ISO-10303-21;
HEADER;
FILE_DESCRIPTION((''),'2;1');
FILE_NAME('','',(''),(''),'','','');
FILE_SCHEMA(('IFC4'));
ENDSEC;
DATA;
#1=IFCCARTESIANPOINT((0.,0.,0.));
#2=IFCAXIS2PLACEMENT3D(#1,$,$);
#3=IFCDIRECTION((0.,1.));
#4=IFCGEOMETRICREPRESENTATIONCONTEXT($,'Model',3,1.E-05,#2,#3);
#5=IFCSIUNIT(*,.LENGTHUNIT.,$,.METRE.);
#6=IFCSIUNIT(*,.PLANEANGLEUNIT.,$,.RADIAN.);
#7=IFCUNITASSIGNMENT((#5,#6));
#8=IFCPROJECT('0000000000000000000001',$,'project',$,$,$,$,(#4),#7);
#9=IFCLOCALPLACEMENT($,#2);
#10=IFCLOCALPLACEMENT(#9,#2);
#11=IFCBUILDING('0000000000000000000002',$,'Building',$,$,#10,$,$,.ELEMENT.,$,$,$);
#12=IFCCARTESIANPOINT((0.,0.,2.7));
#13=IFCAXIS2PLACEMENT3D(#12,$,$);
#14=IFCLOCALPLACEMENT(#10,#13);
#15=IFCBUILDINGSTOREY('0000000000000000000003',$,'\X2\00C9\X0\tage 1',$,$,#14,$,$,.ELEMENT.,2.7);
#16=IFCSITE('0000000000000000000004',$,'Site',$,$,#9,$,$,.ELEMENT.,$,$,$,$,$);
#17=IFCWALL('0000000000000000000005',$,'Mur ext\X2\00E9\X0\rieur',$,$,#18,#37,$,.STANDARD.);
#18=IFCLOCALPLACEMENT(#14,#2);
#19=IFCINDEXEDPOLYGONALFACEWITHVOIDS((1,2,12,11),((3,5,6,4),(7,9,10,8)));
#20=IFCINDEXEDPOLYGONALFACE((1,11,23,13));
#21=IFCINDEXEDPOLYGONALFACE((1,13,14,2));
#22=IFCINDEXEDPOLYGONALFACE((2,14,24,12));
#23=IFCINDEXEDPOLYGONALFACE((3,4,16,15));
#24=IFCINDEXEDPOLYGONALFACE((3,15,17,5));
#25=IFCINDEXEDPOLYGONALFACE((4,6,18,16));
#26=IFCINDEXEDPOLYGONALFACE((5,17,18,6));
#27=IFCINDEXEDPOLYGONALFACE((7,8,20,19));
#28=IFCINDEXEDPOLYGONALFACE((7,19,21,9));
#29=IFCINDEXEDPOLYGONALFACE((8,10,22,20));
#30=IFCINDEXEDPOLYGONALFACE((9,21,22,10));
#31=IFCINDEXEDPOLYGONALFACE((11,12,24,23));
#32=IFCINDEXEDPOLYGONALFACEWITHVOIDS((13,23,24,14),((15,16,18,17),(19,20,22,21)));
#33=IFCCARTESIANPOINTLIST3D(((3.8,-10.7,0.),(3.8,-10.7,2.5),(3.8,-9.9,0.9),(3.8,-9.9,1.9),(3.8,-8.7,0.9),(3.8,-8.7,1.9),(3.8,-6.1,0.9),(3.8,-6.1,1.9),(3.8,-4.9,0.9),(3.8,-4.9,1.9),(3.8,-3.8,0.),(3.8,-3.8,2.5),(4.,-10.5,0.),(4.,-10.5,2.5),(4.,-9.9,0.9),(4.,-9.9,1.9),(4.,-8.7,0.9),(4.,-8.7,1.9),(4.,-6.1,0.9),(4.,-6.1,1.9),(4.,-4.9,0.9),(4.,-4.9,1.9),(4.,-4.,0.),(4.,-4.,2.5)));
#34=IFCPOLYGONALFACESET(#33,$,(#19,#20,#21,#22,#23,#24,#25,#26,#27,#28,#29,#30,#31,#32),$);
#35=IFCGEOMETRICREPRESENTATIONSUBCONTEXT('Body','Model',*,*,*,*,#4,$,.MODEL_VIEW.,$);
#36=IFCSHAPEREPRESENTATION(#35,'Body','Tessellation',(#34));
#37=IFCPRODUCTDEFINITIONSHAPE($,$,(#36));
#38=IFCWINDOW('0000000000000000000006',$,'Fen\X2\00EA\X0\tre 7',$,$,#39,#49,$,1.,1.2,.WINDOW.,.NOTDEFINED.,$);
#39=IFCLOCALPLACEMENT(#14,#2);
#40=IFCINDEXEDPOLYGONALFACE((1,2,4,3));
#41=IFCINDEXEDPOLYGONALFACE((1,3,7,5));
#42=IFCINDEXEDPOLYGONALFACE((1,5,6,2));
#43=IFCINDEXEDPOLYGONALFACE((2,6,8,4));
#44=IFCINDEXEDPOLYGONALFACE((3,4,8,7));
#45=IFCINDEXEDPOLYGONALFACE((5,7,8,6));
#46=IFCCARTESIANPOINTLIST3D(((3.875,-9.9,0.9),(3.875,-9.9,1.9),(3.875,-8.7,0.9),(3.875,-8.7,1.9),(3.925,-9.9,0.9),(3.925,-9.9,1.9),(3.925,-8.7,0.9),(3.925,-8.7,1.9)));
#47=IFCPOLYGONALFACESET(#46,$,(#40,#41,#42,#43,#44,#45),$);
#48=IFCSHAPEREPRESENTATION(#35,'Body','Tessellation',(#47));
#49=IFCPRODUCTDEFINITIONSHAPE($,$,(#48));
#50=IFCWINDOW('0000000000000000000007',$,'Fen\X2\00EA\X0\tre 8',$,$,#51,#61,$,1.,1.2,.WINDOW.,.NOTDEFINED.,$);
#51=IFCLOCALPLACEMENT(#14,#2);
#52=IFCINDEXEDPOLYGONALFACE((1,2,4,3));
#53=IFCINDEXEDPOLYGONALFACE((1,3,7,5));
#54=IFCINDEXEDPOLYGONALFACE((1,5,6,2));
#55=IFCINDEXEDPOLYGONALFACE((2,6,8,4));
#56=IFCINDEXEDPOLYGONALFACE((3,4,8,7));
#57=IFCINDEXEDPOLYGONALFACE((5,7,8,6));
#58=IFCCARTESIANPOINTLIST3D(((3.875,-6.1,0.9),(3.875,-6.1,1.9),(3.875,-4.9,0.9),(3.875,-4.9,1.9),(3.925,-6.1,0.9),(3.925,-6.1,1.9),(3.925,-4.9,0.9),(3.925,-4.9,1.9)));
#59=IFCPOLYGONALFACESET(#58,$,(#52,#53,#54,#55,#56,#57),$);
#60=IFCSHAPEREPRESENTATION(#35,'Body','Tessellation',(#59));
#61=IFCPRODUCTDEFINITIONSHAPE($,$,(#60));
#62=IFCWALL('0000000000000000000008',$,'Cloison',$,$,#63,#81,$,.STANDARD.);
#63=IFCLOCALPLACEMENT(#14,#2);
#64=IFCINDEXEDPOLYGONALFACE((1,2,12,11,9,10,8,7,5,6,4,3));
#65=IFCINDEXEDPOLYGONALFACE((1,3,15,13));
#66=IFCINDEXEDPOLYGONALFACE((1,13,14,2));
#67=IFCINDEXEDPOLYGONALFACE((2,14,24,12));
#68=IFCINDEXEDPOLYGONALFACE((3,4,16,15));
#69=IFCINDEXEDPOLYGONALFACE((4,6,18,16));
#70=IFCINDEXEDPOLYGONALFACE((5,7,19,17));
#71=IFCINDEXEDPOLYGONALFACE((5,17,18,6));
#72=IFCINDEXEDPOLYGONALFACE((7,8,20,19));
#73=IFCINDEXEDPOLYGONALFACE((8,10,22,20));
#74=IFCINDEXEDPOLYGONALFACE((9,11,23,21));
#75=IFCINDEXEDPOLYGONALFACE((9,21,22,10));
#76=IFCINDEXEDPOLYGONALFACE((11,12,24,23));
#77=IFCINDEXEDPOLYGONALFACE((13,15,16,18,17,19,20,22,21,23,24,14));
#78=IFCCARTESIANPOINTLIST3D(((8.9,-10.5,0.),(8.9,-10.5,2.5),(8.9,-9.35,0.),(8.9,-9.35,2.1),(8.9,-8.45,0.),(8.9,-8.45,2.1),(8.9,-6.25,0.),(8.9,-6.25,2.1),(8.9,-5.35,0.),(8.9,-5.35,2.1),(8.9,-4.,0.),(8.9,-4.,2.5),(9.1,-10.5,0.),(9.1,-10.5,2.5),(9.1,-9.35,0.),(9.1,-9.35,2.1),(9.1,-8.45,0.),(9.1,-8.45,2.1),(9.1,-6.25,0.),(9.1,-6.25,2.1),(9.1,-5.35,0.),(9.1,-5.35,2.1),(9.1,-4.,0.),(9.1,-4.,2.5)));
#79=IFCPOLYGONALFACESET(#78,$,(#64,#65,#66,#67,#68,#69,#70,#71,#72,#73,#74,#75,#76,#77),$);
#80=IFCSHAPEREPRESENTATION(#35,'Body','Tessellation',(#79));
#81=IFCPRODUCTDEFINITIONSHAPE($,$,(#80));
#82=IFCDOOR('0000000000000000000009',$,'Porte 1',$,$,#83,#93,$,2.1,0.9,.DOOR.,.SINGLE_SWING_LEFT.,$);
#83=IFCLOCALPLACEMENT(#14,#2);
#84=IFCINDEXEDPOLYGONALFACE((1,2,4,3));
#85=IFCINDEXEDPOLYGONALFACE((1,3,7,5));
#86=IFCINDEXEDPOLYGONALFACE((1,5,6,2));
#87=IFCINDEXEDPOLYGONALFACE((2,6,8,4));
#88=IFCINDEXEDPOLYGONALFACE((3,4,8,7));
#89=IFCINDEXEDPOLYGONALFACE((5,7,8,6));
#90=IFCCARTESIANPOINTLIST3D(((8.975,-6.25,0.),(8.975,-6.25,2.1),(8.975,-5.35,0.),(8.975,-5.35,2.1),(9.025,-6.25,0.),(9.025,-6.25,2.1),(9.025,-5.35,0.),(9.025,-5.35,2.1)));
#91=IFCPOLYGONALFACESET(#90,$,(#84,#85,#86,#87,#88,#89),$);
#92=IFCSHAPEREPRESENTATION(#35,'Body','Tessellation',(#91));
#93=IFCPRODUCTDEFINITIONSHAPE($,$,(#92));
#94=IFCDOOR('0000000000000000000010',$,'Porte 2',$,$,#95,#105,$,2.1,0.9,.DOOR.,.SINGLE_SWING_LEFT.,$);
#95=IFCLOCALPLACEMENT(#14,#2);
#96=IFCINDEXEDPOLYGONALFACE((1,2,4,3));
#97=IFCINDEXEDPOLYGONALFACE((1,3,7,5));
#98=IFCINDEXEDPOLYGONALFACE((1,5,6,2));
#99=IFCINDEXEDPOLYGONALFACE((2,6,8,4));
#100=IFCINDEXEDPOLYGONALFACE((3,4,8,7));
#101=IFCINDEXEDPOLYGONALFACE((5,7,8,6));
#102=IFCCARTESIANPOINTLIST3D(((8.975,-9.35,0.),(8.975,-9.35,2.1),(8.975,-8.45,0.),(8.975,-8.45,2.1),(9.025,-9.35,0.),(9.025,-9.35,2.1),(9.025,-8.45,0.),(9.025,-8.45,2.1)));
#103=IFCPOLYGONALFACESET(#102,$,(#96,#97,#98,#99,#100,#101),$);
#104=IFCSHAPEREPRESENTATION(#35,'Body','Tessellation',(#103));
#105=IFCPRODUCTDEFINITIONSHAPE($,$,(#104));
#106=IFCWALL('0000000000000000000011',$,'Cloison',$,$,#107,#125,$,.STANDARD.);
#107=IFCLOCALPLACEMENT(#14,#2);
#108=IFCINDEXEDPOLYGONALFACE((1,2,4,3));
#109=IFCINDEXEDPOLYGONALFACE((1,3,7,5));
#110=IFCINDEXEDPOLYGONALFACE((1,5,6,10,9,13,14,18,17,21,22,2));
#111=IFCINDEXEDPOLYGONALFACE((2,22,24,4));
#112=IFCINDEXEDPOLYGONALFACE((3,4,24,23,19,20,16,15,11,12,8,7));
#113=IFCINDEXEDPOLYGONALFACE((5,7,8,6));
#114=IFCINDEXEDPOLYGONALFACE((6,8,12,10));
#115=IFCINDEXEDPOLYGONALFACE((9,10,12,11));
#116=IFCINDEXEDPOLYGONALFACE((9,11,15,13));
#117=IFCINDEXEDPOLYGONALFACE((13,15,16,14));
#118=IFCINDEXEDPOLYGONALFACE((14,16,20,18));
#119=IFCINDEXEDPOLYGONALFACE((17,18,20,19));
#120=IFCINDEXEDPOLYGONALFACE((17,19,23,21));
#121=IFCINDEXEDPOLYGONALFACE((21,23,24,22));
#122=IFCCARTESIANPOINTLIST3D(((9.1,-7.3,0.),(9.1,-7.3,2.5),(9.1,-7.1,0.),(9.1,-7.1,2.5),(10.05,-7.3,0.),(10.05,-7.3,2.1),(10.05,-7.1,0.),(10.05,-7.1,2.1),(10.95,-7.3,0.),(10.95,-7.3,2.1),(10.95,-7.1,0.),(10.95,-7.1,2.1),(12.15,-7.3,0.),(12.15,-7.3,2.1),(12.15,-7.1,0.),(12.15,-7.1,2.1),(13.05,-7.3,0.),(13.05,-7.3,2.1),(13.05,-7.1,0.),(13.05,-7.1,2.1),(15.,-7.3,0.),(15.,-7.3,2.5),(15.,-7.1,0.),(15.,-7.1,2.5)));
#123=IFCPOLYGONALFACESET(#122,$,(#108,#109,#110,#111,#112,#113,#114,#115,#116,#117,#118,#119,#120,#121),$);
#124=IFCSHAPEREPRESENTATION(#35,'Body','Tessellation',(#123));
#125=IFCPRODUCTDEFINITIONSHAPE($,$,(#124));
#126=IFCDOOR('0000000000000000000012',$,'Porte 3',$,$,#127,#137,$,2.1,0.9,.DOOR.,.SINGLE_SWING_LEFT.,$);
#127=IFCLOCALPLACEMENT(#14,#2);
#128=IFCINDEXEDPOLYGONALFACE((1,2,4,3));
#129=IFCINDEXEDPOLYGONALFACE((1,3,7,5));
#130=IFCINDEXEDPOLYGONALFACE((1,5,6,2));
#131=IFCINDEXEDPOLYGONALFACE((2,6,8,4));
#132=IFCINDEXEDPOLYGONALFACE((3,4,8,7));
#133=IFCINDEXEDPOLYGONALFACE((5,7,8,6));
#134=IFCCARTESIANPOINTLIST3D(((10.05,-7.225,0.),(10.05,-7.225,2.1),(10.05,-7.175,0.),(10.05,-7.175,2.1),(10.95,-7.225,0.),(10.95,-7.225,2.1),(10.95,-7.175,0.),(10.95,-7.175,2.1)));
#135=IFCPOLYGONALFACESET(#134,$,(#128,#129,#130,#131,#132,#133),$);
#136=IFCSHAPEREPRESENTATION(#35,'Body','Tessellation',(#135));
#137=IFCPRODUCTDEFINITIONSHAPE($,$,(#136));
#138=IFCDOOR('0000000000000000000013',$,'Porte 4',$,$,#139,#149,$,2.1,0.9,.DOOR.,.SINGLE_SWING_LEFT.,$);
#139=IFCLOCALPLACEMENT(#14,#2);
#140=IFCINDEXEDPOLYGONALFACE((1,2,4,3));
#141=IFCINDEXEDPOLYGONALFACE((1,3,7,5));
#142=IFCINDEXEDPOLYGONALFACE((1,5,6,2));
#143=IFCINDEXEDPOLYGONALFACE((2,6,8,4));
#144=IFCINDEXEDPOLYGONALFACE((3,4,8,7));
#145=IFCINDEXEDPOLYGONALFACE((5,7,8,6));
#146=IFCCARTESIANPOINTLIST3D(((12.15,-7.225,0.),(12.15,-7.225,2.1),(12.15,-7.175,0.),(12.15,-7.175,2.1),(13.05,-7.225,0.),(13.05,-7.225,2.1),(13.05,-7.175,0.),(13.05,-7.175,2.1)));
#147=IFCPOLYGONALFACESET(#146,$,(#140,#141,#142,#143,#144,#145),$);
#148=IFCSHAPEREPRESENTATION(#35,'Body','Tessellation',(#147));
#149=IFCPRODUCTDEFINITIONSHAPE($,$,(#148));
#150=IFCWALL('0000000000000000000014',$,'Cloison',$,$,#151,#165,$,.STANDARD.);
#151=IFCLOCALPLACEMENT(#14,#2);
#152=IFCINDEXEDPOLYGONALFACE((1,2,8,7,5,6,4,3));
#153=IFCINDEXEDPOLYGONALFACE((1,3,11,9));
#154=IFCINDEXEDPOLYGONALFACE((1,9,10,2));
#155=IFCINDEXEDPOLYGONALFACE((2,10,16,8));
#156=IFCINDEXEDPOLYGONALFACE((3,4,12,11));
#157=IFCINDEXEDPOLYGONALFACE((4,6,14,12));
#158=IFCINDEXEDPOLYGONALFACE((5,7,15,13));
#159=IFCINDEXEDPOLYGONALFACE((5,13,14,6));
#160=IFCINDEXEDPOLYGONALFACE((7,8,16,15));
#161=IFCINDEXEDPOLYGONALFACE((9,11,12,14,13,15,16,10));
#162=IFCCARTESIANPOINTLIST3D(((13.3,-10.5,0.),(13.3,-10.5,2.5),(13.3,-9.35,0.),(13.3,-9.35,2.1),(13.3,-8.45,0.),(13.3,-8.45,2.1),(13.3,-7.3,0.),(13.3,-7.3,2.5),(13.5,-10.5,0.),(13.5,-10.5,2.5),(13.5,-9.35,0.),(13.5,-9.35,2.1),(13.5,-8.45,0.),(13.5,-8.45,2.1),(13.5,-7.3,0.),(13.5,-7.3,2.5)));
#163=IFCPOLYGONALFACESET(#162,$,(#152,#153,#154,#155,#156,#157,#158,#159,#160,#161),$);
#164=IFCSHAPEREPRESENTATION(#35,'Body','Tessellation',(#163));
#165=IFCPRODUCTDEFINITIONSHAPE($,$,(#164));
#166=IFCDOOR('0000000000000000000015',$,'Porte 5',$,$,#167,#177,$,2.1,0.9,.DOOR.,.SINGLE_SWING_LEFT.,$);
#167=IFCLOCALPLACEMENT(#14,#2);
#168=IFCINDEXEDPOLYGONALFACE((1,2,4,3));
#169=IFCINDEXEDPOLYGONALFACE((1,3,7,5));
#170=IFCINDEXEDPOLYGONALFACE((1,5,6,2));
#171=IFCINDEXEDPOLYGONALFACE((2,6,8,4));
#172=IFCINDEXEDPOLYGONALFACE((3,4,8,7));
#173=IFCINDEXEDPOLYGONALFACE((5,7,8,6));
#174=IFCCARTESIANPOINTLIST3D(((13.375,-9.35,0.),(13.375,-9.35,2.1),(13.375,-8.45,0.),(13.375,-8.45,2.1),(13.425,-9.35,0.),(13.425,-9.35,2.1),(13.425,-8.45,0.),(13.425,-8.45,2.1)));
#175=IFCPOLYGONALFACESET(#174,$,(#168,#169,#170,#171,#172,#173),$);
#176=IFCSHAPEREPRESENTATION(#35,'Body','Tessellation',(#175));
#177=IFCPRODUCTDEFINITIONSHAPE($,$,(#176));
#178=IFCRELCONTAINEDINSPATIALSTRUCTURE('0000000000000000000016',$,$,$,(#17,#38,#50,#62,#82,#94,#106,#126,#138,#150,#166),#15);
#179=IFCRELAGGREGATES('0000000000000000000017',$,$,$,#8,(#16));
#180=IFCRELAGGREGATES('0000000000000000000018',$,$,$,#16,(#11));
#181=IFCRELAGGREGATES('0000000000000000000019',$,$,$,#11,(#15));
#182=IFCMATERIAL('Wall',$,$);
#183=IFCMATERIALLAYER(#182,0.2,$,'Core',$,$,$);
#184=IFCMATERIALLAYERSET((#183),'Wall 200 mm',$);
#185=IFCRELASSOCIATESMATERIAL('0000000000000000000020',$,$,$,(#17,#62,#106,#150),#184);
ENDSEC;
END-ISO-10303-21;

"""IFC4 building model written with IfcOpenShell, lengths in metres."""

from ifc_helpers import new_model, si_unit, direction, frame, origin, origin_2d, place, context, subcontext, project, spatial, polyline, rectangle, outline, extrude, material, layer, layer_set, layer_usage, element, fill, save


model = new_model("IFC4")

# Units and contexts
model_context = context("Model", 3, precision=1e-05, world=origin(), true_north=direction((0.0, 1.0)))
body_context = subcontext(model_context, "Body", "Model", "MODEL_VIEW")
ifc_project = project(units=[si_unit("LENGTHUNIT", "METRE"), si_unit("PLANEANGLEUNIT", "RADIAN")], contexts=[model_context])

# Site, building, storey
site_placement = place(None, origin())
site = spatial("IfcSite", under=ifc_project, at=site_placement, Name="Site", CompositionType="ELEMENT")
building_placement = place(site_placement, origin())
building = spatial("IfcBuilding", under=site, at=building_placement, Name="Building", CompositionType="ELEMENT")
storey_placement = place(building_placement, frame((0.0, 0.0, 2.7)))
storey = spatial("IfcBuildingStorey", under=building, at=storey_placement, Name="Étage 1", CompositionType="ELEMENT", Elevation=2.7)

# Shared definitions
ifc_material = material(Name="Wall")
ifc_layer = layer(ifc_material, 0.2, Name="Core")
ifc_layer_set = layer_set([ifc_layer], Name="Wall 200 mm")
ifc_layer_usage = layer_usage(ifc_layer_set, "AXIS2", "POSITIVE", -0.1)

# Wall, openings, windows
wall_1_placement = place(storey_placement, frame((3.9, -10.6, 0.0), z_axis=(0.0, 0.0, 1.0), x_axis=(0.0, 1.0, 0.0)))
wall_1 = element("IfcWall", 1, at=wall_1_placement, inside=storey, material=ifc_layer_usage, Name="Mur extérieur", PredefinedType="STANDARD", context=body_context, shape_type="SweptSolid", body=[
    extrude(outline(polyline([(0.0, 0.0), (0.1, -0.1), (6.6, -0.1), (6.7, 0.0), (6.8, 0.1), (-0.1, 0.1), (0.0, 0.0)])), origin(), (0.0, 0.0, 1.0), 2.5),
])
opening_1_placement = place(wall_1_placement, frame((1.3, 0.0, 0.9)))
opening_1 = element("IfcOpeningElement", 2, at=opening_1_placement, cuts=wall_1, PredefinedType="OPENING", context=body_context, shape_type="SweptSolid", body=[
    extrude(rectangle(XDim=1.2, YDim=0.4, at=origin_2d()), origin(), (0.0, 0.0, 1.0), 1.0),
])
opening_2_placement = place(wall_1_placement, frame((5.1, 0.0, 0.9)))
opening_2 = element("IfcOpeningElement", 3, at=opening_2_placement, cuts=wall_1, PredefinedType="OPENING", context=body_context, shape_type="SweptSolid", body=[
    extrude(rectangle(XDim=1.2, YDim=0.4, at=origin_2d()), origin(), (0.0, 0.0, 1.0), 1.0),
])
window_1_placement = place(opening_1_placement, origin())
window_1 = element("IfcWindow", 4, at=window_1_placement, inside=storey, Name="Fenêtre 7", OverallHeight=1.0, OverallWidth=1.2, PartitioningType="NOTDEFINED", PredefinedType="WINDOW", context=body_context, shape_type="SweptSolid", body=[
    extrude(rectangle(XDim=1.2, YDim=0.05, at=origin_2d()), origin(), (0.0, 0.0, 1.0), 1.0),
])
fill(opening_1, window_1)
window_2_placement = place(opening_2_placement, origin())
window_2 = element("IfcWindow", 5, at=window_2_placement, inside=storey, Name="Fenêtre 8", OverallHeight=1.0, OverallWidth=1.2, PartitioningType="NOTDEFINED", PredefinedType="WINDOW", context=body_context, shape_type="SweptSolid", body=[
    extrude(rectangle(XDim=1.2, YDim=0.05, at=origin_2d()), origin(), (0.0, 0.0, 1.0), 1.0),
])
fill(opening_2, window_2)

# Wall, openings, doors
wall_2_placement = place(storey_placement, frame((9.0, -3.9, 0.0), z_axis=(0.0, 0.0, 1.0), x_axis=(0.0, -1.0, 0.0)))
wall_2 = element("IfcWall", 6, at=wall_2_placement, inside=storey, material=ifc_layer_usage, Name="Cloison", PredefinedType="STANDARD", context=body_context, shape_type="SweptSolid", body=[
    extrude(outline(polyline([(0.1, 0.0), (0.1, -0.1), (6.6, -0.1), (6.6, 0.0), (6.6, 0.1), (0.1, 0.1), (0.1, 0.0)])), origin(), (0.0, 0.0, 1.0), 2.5),
])
opening_3_placement = place(wall_2_placement, frame((1.9, 0.0, 0.0)))
opening_3 = element("IfcOpeningElement", 7, at=opening_3_placement, cuts=wall_2, PredefinedType="OPENING", context=body_context, shape_type="SweptSolid", body=[
    extrude(rectangle(XDim=0.9, YDim=0.4, at=origin_2d()), origin(), (0.0, 0.0, 1.0), 2.1),
])
opening_4_placement = place(wall_2_placement, frame((5.0, 0.0, 0.0)))
opening_4 = element("IfcOpeningElement", 8, at=opening_4_placement, cuts=wall_2, PredefinedType="OPENING", context=body_context, shape_type="SweptSolid", body=[
    extrude(rectangle(XDim=0.9, YDim=0.4, at=origin_2d()), origin(), (0.0, 0.0, 1.0), 2.1),
])
door_1_placement = place(opening_3_placement, origin())
door_1 = element("IfcDoor", 9, at=door_1_placement, inside=storey, Name="Porte 1", OperationType="SINGLE_SWING_LEFT", OverallHeight=2.1, OverallWidth=0.9, PredefinedType="DOOR", context=body_context, shape_type="SweptSolid", body=[
    extrude(rectangle(XDim=0.9, YDim=0.05, at=origin_2d()), origin(), (0.0, 0.0, 1.0), 2.1),
])
fill(opening_3, door_1)
door_2_placement = place(opening_4_placement, origin())
door_2 = element("IfcDoor", 10, at=door_2_placement, inside=storey, Name="Porte 2", OperationType="SINGLE_SWING_LEFT", OverallHeight=2.1, OverallWidth=0.9, PredefinedType="DOOR", context=body_context, shape_type="SweptSolid", body=[
    extrude(rectangle(XDim=0.9, YDim=0.05, at=origin_2d()), origin(), (0.0, 0.0, 1.0), 2.1),
])
fill(opening_4, door_2)

# Wall, openings, doors
wall_3_placement = place(storey_placement, frame((9.0, -7.2, 0.0)))
wall_3 = element("IfcWall", 11, at=wall_3_placement, inside=storey, material=ifc_layer_usage, Name="Cloison", PredefinedType="STANDARD", context=body_context, shape_type="SweptSolid", body=[
    extrude(outline(polyline([(0.1, 0.0), (0.1, -0.1), (6.0, -0.1), (6.0, 0.0), (6.0, 0.1), (0.1, 0.1), (0.1, 0.0)])), origin(), (0.0, 0.0, 1.0), 2.5),
])
opening_5_placement = place(wall_3_placement, frame((1.5, 0.0, 0.0)))
opening_5 = element("IfcOpeningElement", 12, at=opening_5_placement, cuts=wall_3, PredefinedType="OPENING", context=body_context, shape_type="SweptSolid", body=[
    extrude(rectangle(XDim=0.9, YDim=0.4, at=origin_2d()), origin(), (0.0, 0.0, 1.0), 2.1),
])
opening_6_placement = place(wall_3_placement, frame((3.6, 0.0, 0.0)))
opening_6 = element("IfcOpeningElement", 13, at=opening_6_placement, cuts=wall_3, PredefinedType="OPENING", context=body_context, shape_type="SweptSolid", body=[
    extrude(rectangle(XDim=0.9, YDim=0.4, at=origin_2d()), origin(), (0.0, 0.0, 1.0), 2.1),
])
door_3_placement = place(opening_5_placement, origin())
door_3 = element("IfcDoor", 14, at=door_3_placement, inside=storey, Name="Porte 3", OperationType="SINGLE_SWING_LEFT", OverallHeight=2.1, OverallWidth=0.9, PredefinedType="DOOR", context=body_context, shape_type="SweptSolid", body=[
    extrude(rectangle(XDim=0.9, YDim=0.05, at=origin_2d()), origin(), (0.0, 0.0, 1.0), 2.1),
])
fill(opening_5, door_3)
door_4_placement = place(opening_6_placement, origin())
door_4 = element("IfcDoor", 15, at=door_4_placement, inside=storey, Name="Porte 4", OperationType="SINGLE_SWING_LEFT", OverallHeight=2.1, OverallWidth=0.9, PredefinedType="DOOR", context=body_context, shape_type="SweptSolid", body=[
    extrude(rectangle(XDim=0.9, YDim=0.05, at=origin_2d()), origin(), (0.0, 0.0, 1.0), 2.1),
])
fill(opening_6, door_4)

# Wall, opening, door
wall_4_placement = place(storey_placement, frame((13.4, -7.2, 0.0), z_axis=(0.0, 0.0, 1.0), x_axis=(0.0, -1.0, 0.0)))
wall_4 = element("IfcWall", 16, at=wall_4_placement, inside=storey, material=ifc_layer_usage, Name="Cloison", PredefinedType="STANDARD", context=body_context, shape_type="SweptSolid", body=[
    extrude(outline(polyline([(0.1, 0.0), (0.1, -0.1), (3.3, -0.1), (3.3, 0.0), (3.3, 0.1), (0.1, 0.1), (0.1, 0.0)])), origin(), (0.0, 0.0, 1.0), 2.5),
])
opening_7_placement = place(wall_4_placement, frame((1.7, 0.0, 0.0)))
opening_7 = element("IfcOpeningElement", 17, at=opening_7_placement, cuts=wall_4, PredefinedType="OPENING", context=body_context, shape_type="SweptSolid", body=[
    extrude(rectangle(XDim=0.9, YDim=0.4, at=origin_2d()), origin(), (0.0, 0.0, 1.0), 2.1),
])
door_5_placement = place(opening_7_placement, origin())
door_5 = element("IfcDoor", 18, at=door_5_placement, inside=storey, Name="Porte 5", OperationType="SINGLE_SWING_LEFT", OverallHeight=2.1, OverallWidth=0.9, PredefinedType="DOOR", context=body_context, shape_type="SweptSolid", body=[
    extrude(rectangle(XDim=0.9, YDim=0.05, at=origin_2d()), origin(), (0.0, 0.0, 1.0), 2.1),
])
fill(opening_7, door_5)

save(model, "model.ifc")
